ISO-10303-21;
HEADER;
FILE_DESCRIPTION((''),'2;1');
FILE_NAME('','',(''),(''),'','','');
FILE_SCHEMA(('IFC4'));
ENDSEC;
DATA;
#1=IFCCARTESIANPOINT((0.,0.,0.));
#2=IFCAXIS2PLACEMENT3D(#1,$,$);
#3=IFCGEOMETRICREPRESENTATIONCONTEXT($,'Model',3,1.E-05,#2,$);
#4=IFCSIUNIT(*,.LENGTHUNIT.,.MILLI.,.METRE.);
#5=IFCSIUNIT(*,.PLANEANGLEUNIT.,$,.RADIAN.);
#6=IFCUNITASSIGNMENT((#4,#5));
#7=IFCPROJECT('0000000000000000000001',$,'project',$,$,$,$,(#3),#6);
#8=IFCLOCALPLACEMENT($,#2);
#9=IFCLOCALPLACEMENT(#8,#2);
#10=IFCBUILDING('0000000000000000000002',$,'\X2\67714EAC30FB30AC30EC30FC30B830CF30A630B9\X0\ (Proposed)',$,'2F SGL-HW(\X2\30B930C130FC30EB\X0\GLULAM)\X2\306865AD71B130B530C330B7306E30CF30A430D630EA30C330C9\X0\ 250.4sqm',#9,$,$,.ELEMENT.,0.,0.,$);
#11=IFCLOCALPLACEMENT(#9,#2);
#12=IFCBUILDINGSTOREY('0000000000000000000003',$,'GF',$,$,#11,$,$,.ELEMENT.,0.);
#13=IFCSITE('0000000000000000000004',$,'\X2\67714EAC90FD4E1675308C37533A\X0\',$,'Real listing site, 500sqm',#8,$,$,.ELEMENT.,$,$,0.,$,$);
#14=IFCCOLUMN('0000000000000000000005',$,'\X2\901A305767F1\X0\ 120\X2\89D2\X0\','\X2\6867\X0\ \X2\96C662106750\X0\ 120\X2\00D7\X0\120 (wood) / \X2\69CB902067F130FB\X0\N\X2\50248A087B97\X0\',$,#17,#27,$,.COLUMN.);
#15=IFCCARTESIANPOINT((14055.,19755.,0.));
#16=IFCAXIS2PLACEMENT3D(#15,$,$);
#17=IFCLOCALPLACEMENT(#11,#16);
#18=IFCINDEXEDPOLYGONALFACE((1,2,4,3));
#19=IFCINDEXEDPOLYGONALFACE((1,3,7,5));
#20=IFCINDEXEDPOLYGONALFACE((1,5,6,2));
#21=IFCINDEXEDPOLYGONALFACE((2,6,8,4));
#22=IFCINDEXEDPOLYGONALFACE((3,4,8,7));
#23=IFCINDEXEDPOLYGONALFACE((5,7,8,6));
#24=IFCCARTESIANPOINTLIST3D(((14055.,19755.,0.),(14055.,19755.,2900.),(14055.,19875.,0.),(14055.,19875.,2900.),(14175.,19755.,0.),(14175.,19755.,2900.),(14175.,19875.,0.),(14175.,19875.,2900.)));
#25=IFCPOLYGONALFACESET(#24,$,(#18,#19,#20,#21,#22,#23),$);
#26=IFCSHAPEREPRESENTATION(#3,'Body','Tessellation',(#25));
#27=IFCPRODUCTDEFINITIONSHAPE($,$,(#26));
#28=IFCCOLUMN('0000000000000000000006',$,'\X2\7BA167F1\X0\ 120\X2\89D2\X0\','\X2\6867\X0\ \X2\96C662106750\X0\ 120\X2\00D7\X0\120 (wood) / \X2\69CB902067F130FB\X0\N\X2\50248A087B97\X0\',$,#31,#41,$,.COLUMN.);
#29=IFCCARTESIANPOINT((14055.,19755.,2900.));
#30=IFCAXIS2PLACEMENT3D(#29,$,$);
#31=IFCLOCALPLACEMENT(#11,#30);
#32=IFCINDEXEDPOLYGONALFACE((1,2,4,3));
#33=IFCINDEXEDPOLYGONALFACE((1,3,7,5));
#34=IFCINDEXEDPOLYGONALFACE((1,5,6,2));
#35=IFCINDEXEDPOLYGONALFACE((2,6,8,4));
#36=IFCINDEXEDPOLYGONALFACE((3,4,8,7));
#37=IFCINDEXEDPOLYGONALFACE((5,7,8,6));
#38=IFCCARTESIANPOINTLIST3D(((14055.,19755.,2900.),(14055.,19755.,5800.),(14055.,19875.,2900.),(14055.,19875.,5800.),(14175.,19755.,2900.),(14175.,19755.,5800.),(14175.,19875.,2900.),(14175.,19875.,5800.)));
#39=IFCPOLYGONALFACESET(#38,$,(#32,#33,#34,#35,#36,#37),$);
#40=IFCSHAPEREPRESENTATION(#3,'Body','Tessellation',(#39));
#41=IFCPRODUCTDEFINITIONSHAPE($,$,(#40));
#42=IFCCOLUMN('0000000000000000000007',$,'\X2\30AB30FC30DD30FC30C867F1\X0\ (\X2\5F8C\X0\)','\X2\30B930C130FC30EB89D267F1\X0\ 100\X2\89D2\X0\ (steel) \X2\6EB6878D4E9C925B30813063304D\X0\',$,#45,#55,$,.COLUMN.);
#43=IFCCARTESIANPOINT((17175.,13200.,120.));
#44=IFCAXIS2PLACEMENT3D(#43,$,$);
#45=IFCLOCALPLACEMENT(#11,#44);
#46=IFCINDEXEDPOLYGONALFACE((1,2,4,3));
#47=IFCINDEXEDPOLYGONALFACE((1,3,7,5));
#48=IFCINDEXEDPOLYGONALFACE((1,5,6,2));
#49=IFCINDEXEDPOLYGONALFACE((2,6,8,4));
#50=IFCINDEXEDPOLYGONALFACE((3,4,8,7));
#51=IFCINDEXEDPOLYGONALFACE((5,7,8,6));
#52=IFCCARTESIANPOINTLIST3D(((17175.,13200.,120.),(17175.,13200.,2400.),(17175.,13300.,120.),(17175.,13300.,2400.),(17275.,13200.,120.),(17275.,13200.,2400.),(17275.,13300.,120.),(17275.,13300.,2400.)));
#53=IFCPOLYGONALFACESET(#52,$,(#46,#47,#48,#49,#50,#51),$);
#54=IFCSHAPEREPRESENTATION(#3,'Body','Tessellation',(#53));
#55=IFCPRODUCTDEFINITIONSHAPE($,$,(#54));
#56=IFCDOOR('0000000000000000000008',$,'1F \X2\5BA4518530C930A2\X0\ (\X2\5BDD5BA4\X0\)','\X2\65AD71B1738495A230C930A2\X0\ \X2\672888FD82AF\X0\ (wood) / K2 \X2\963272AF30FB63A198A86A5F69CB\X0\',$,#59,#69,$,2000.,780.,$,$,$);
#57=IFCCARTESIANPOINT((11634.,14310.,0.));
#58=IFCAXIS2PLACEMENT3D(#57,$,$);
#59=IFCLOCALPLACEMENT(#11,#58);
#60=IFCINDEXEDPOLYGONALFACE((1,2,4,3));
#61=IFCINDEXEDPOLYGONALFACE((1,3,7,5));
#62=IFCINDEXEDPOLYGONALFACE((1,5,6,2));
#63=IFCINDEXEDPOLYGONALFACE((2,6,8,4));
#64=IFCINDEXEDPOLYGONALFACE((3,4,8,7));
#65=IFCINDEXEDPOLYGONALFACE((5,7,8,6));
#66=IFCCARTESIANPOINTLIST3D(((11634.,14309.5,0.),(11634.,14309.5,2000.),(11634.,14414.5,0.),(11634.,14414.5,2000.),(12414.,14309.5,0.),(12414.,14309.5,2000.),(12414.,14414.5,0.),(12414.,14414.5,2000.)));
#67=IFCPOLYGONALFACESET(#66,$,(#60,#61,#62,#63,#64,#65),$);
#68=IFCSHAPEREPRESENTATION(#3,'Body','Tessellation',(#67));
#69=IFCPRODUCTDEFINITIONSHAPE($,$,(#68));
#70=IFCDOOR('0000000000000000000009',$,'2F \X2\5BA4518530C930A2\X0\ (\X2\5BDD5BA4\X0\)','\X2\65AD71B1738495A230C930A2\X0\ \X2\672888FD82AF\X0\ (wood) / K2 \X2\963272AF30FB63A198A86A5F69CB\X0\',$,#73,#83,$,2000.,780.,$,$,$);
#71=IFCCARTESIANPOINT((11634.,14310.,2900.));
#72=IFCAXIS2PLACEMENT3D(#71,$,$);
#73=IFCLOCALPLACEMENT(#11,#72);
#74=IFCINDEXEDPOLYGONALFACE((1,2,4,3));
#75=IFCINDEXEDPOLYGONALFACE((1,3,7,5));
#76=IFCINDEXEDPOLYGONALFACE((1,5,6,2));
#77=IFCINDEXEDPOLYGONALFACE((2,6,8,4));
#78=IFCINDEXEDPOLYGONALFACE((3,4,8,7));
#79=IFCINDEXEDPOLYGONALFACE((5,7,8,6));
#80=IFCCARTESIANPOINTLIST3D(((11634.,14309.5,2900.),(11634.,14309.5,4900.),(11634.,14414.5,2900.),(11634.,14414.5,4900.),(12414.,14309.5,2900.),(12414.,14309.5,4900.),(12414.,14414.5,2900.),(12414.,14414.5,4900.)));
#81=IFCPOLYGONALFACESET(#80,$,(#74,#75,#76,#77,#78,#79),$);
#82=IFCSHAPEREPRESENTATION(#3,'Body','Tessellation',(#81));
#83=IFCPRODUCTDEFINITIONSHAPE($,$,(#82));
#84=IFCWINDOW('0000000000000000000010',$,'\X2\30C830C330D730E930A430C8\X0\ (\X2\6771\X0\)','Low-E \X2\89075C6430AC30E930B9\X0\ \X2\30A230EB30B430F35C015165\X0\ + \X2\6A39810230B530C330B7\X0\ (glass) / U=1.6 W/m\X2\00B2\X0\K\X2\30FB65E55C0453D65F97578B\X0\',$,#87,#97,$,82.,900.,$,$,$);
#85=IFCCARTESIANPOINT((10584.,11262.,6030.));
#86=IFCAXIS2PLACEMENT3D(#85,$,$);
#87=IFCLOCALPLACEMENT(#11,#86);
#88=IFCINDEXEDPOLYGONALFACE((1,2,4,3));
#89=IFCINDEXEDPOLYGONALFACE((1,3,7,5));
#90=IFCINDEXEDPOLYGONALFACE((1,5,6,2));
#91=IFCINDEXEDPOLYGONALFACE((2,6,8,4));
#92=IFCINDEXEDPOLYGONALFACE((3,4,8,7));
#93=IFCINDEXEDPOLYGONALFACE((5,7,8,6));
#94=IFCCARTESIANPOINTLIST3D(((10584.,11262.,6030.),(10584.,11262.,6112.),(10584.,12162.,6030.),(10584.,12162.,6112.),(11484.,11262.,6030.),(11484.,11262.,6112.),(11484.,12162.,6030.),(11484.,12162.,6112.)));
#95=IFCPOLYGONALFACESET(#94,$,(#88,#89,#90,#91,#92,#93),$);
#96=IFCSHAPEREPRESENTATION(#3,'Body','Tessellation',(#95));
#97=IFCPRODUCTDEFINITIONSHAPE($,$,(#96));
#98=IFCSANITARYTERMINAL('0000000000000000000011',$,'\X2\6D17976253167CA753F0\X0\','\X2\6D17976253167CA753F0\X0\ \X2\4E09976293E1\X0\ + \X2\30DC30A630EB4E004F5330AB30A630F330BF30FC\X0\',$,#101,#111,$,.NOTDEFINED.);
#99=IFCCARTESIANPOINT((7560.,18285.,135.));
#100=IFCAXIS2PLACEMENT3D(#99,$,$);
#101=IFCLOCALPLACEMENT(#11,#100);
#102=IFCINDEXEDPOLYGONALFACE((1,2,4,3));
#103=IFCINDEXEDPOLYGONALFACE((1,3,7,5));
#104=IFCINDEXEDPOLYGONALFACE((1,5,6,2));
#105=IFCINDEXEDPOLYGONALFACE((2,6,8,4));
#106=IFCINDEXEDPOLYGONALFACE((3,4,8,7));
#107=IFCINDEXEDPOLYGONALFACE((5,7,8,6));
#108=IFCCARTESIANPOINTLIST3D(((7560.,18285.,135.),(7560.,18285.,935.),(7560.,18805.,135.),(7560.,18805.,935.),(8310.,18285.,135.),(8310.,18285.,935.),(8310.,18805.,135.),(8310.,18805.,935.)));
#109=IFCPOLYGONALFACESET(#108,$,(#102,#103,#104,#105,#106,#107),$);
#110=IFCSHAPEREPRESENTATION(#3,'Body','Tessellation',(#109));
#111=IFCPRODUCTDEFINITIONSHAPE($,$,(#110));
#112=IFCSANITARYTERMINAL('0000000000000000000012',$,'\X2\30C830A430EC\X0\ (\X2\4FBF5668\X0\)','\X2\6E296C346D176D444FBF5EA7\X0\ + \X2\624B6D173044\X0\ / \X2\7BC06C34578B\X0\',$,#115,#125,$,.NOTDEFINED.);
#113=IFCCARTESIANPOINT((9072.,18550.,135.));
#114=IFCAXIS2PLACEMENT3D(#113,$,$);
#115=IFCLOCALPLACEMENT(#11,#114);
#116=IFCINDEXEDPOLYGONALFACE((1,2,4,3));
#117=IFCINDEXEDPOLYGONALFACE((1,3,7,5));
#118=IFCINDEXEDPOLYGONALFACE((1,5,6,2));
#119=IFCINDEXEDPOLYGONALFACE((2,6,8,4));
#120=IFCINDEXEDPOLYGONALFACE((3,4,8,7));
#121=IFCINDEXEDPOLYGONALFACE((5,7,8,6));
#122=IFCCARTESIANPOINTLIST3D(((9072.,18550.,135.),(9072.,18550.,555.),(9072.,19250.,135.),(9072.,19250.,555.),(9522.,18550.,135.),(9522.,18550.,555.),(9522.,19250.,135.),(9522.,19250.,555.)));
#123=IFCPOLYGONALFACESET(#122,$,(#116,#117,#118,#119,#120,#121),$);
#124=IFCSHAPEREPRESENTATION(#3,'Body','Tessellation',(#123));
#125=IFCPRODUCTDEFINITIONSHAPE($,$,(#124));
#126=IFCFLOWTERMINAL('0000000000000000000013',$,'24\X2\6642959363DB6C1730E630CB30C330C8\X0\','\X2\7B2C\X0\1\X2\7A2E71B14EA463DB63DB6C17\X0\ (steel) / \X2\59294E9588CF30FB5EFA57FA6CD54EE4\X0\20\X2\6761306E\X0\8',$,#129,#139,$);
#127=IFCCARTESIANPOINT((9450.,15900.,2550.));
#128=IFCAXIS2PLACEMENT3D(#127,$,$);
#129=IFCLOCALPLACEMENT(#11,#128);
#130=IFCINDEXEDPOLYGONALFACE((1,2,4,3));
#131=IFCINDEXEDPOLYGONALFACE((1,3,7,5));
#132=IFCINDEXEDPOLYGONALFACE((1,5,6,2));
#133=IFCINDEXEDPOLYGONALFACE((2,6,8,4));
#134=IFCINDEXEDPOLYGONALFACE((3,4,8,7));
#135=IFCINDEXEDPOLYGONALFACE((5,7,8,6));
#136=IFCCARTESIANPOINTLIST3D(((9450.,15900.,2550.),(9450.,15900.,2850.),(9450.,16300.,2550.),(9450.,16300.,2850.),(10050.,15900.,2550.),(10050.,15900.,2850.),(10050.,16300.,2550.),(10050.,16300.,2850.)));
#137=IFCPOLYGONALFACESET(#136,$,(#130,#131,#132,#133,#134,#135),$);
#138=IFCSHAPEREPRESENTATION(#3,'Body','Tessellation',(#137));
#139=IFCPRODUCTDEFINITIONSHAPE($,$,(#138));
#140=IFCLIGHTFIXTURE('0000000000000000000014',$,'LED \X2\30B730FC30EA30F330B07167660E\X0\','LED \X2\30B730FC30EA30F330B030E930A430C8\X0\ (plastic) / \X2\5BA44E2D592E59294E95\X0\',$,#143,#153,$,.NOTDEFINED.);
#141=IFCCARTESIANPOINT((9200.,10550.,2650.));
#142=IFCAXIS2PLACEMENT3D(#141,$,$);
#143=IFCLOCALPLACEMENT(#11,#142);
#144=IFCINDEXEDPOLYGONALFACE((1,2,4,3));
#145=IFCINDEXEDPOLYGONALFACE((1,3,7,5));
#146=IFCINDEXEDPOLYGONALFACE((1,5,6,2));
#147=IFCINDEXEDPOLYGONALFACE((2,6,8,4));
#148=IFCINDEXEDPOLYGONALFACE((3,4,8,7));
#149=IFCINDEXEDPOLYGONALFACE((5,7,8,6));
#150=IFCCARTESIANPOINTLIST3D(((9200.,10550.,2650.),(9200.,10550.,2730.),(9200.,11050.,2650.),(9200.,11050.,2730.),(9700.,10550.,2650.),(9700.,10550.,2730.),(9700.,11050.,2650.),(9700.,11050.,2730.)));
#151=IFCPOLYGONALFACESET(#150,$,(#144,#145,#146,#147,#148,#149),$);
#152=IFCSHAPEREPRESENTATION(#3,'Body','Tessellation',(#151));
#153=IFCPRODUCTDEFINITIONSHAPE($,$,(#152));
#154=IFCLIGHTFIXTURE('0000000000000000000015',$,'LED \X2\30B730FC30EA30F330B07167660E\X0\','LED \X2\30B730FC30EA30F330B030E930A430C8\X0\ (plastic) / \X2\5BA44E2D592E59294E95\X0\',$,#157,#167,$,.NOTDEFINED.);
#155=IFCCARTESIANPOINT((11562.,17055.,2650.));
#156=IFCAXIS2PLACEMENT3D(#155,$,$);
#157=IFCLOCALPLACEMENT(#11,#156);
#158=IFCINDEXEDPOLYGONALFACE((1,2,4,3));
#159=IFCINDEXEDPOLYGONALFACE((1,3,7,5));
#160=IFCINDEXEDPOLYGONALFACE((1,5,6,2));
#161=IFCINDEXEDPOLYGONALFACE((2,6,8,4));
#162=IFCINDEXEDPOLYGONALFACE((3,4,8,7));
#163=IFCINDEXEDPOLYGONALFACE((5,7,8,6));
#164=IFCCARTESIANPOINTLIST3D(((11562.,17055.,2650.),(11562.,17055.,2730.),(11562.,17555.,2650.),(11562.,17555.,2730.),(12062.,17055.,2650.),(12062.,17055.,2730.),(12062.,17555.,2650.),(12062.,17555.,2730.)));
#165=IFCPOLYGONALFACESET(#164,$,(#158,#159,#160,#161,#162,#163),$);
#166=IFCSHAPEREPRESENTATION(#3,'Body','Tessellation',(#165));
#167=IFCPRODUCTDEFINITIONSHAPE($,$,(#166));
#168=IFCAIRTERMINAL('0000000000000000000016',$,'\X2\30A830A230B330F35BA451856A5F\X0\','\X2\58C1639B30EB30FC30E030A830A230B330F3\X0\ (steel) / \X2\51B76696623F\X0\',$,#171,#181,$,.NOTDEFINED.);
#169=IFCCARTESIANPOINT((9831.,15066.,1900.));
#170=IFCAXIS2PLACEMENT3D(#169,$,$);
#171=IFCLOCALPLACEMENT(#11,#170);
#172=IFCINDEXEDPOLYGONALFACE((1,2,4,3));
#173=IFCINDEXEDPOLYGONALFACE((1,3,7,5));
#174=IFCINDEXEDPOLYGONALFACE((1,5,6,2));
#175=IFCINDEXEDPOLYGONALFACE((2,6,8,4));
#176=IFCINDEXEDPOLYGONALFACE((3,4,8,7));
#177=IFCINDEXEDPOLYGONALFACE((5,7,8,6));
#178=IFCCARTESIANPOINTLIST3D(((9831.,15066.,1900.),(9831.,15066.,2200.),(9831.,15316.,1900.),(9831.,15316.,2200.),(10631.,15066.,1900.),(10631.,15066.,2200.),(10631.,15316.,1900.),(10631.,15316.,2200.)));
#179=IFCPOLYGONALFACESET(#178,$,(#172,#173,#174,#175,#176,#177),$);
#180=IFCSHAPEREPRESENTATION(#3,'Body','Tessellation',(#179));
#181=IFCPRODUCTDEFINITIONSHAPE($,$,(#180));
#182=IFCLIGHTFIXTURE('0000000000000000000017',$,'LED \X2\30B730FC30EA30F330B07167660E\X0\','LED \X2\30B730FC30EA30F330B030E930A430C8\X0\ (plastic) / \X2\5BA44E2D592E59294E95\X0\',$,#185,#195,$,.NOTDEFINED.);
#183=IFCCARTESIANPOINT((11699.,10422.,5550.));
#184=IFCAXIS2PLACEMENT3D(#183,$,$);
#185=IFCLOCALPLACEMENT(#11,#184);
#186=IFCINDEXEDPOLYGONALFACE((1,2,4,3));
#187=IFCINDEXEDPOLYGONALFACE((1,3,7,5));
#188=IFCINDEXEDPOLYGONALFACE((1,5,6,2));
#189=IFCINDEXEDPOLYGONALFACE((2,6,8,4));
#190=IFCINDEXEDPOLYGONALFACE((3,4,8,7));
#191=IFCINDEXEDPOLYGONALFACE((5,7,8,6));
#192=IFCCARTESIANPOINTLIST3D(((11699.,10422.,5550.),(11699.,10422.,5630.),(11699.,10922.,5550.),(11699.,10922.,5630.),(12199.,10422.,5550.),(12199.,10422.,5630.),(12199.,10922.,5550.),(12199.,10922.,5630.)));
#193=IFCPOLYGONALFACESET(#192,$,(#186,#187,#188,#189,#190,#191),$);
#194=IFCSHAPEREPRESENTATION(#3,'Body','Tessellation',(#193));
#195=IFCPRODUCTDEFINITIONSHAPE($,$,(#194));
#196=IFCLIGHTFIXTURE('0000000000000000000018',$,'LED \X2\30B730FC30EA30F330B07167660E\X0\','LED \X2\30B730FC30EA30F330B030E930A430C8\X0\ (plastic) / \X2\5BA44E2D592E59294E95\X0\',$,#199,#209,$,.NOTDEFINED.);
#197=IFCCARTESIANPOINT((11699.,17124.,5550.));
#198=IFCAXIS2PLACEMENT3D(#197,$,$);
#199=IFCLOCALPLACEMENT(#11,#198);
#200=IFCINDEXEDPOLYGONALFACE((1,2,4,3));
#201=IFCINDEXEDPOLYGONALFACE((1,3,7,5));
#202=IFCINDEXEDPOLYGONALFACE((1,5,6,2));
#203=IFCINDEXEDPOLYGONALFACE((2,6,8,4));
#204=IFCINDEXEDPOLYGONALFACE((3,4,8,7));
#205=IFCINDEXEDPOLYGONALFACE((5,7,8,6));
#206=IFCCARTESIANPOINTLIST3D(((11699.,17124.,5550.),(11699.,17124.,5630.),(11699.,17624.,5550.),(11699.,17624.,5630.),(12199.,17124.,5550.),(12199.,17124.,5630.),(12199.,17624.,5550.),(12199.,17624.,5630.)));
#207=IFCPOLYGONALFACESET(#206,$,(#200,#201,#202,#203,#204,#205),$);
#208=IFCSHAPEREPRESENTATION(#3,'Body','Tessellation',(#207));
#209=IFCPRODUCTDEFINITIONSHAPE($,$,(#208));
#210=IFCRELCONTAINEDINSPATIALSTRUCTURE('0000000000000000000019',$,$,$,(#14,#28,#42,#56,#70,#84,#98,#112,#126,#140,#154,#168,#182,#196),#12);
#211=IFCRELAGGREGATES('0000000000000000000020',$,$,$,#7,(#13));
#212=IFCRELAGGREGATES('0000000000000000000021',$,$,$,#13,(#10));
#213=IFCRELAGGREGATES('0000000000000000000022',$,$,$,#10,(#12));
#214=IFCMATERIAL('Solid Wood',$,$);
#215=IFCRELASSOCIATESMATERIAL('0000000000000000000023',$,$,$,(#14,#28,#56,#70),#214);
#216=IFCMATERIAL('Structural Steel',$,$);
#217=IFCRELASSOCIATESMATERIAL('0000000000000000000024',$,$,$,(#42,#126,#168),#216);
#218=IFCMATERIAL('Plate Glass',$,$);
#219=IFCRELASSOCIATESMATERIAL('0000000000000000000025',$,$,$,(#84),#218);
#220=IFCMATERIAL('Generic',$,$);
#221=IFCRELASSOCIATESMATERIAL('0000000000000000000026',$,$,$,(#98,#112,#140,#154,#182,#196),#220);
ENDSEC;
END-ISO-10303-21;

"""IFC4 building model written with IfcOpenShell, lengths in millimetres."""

from ifc_helpers import new_model, si_unit, frame, frame_2d, origin, place, context, project, spatial, rectangle, extrude, material, element, save


model = new_model("IFC4")

# Units and contexts
model_context = context("Model", 3, precision=1e-05, world=origin())
ifc_project = project(units=[si_unit("LENGTHUNIT", "METRE", prefix="MILLI"), si_unit("PLANEANGLEUNIT", "RADIAN")], contexts=[model_context])

# Site, building, storey
site_placement = place(None, origin())
site = spatial("IfcSite", under=ifc_project, at=site_placement, Name="東京都世田谷区", ObjectType="Real listing site, 500sqm", CompositionType="ELEMENT", RefElevation=0.0)
building_placement = place(site_placement, origin())
building = spatial("IfcBuilding", under=site, at=building_placement, Name="東京・ガレージハウス (Proposed)", ObjectType="2F SGL-HW(スチールGLULAM)と断熱サッシのハイブリッド 250.4sqm", CompositionType="ELEMENT", ElevationOfRefHeight=0.0, ElevationOfTerrain=0.0)
storey_placement = place(building_placement, origin())
storey = spatial("IfcBuildingStorey", under=building, at=storey_placement, Name="GF", CompositionType="ELEMENT", Elevation=0.0)

# Columns
ifc_material_1 = material(Name="Solid Wood")
column_1_placement = place(storey_placement, frame((14055.0, 19755.0, 0.0)))
element("IfcColumn", 1, at=column_1_placement, inside=storey, material=ifc_material_1, Name="通し柱 120角", Description="桧 集成材 120×120 (wood) / 構造柱・N値計算", PredefinedType="COLUMN", context=model_context, shape_type="SweptSolid", body=[
    extrude(rectangle(XDim=120.0, YDim=120.0, at=frame_2d((60.0, 60.0))), frame((14055.0, 19755.0, 0.0)), (0.0, 0.0, 1.0), 2900.0),
])
column_2_placement = place(storey_placement, frame((14055.0, 19755.0, 2900.0)))
element("IfcColumn", 2, at=column_2_placement, inside=storey, material=ifc_material_1, Name="管柱 120角", Description="桧 集成材 120×120 (wood) / 構造柱・N値計算", PredefinedType="COLUMN", context=model_context, shape_type="SweptSolid", body=[
    extrude(rectangle(XDim=120.0, YDim=120.0, at=frame_2d((60.0, 60.0))), frame((14055.0, 19755.0, 2900.0)), (0.0, 0.0, 1.0), 2900.0),
])
ifc_material_2 = material(Name="Structural Steel")
column_3_placement = place(storey_placement, frame((17175.0, 13200.0, 120.0)))
element("IfcColumn", 3, at=column_3_placement, inside=storey, material=ifc_material_2, Name="カーポート柱 (後)", Description="スチール角柱 100角 (steel) 溶融亜鉛めっき", PredefinedType="COLUMN", context=model_context, shape_type="SweptSolid", body=[
    extrude(rectangle(XDim=100.0, YDim=100.0, at=frame_2d((50.0, 50.0))), frame((17175.0, 13200.0, 120.0)), (0.0, 0.0, 1.0), 2280.0),
])

# Door
door_1_placement = place(storey_placement, frame((11634.0, 14310.0, 0.0)))
element("IfcDoor", 4, at=door_1_placement, inside=storey, material=ifc_material_1, Name="1F 室内ドア (寝室)", Description="断熱玄関ドア 木製芯 (wood) / K2 防犯・採風機構", OverallHeight=2000.0, OverallWidth=780.0, context=model_context, shape_type="SweptSolid", body=[
    extrude(rectangle(XDim=780.0, YDim=105.0, at=frame_2d((390.0, 52.0))), frame((11634.0, 14310.0, 0.0)), (0.0, 0.0, 1.0), 2000.0),
])

# Door
door_2_placement = place(storey_placement, frame((11634.0, 14310.0, 2900.0)))
element("IfcDoor", 5, at=door_2_placement, inside=storey, material=ifc_material_1, Name="2F 室内ドア (寝室)", Description="断熱玄関ドア 木製芯 (wood) / K2 防犯・採風機構", OverallHeight=2000.0, OverallWidth=780.0, context=model_context, shape_type="SweptSolid", body=[
    extrude(rectangle(XDim=780.0, YDim=105.0, at=frame_2d((390.0, 52.0))), frame((11634.0, 14310.0, 2900.0)), (0.0, 0.0, 1.0), 2000.0),
])

# Window
ifc_material_3 = material(Name="Plate Glass")
window_placement = place(storey_placement, frame((10584.0, 11262.0, 6030.0)))
element("IfcWindow", 6, at=window_placement, inside=storey, material=ifc_material_3, Name="トップライト (東)", Description="Low-E 複層ガラス アルゴン封入 + 樹脂サッシ (glass) / U=1.6 W/m²K・日射取得型", OverallHeight=82.0, OverallWidth=900.0, context=model_context, shape_type="SweptSolid", body=[
    extrude(rectangle(XDim=900.0, YDim=900.0, at=frame_2d((450.0, 450.0))), frame((10584.0, 11262.0, 6030.0)), (0.0, 0.0, 1.0), 82.0),
])

# Sanitary terminals
ifc_material_4 = material(Name="Generic")
sanitary_terminal_1_placement = place(storey_placement, frame((7560.0, 18285.0, 135.0)))
element("IfcSanitaryTerminal", 7, at=sanitary_terminal_1_placement, inside=storey, material=ifc_material_4, Name="洗面化粧台", Description="洗面化粧台 三面鏡 + ボウル一体カウンター", PredefinedType="NOTDEFINED", context=model_context, shape_type="SweptSolid", body=[
    extrude(rectangle(XDim=750.0, YDim=520.0, at=frame_2d((375.0, 260.0))), frame((7560.0, 18285.0, 135.0)), (0.0, 0.0, 1.0), 800.0),
])
sanitary_terminal_2_placement = place(storey_placement, frame((9072.0, 18550.0, 135.0)))
element("IfcSanitaryTerminal", 8, at=sanitary_terminal_2_placement, inside=storey, material=ifc_material_4, Name="トイレ (便器)", Description="温水洗浄便座 + 手洗い / 節水型", PredefinedType="NOTDEFINED", context=model_context, shape_type="SweptSolid", body=[
    extrude(rectangle(XDim=450.0, YDim=700.0, at=frame_2d((225.0, 350.0))), frame((9072.0, 18550.0, 135.0)), (0.0, 0.0, 1.0), 420.0),
])

# Flow terminal
flow_terminal_placement = place(storey_placement, frame((9450.0, 15900.0, 2550.0)))
element("IfcFlowTerminal", 9, at=flow_terminal_placement, inside=storey, material=ifc_material_2, Name="24時間換気ユニット", Description="第1種熱交換換気 (steel) / 天井裏・建基法令20条の8", context=model_context, shape_type="SweptSolid", body=[
    extrude(rectangle(XDim=600.0, YDim=400.0, at=frame_2d((300.0, 200.0))), frame((9450.0, 15900.0, 2550.0)), (0.0, 0.0, 1.0), 300.0),
])

# Light fixtures
light_fixture_1_placement = place(storey_placement, frame((9200.0, 10550.0, 2650.0)))
element("IfcLightFixture", 10, at=light_fixture_1_placement, inside=storey, material=ifc_material_4, Name="LED シーリング照明", Description="LED シーリングライト (plastic) / 室中央天井", PredefinedType="NOTDEFINED", context=model_context, shape_type="SweptSolid", body=[
    extrude(rectangle(XDim=500.0, YDim=500.0, at=frame_2d((250.0, 250.0))), frame((9200.0, 10550.0, 2650.0)), (0.0, 0.0, 1.0), 80.0),
])
light_fixture_2_placement = place(storey_placement, frame((11562.0, 17055.0, 2650.0)))
element("IfcLightFixture", 11, at=light_fixture_2_placement, inside=storey, material=ifc_material_4, Name="LED シーリング照明", Description="LED シーリングライト (plastic) / 室中央天井", PredefinedType="NOTDEFINED", context=model_context, shape_type="SweptSolid", body=[
    extrude(rectangle(XDim=500.0, YDim=500.0, at=frame_2d((250.0, 250.0))), frame((11562.0, 17055.0, 2650.0)), (0.0, 0.0, 1.0), 80.0),
])

# Air terminal
air_terminal_placement = place(storey_placement, frame((9831.0, 15066.0, 1900.0)))
element("IfcAirTerminal", 12, at=air_terminal_placement, inside=storey, material=ifc_material_2, Name="エアコン室内機", Description="壁掛ルームエアコン (steel) / 冷暖房", PredefinedType="NOTDEFINED", context=model_context, shape_type="SweptSolid", body=[
    extrude(rectangle(XDim=800.0, YDim=250.0, at=frame_2d((400.0, 125.0))), frame((9831.0, 15066.0, 1900.0)), (0.0, 0.0, 1.0), 300.0),
])

# Light fixtures
light_fixture_3_placement = place(storey_placement, frame((11699.0, 10422.0, 5550.0)))
element("IfcLightFixture", 13, at=light_fixture_3_placement, inside=storey, material=ifc_material_4, Name="LED シーリング照明", Description="LED シーリングライト (plastic) / 室中央天井", PredefinedType="NOTDEFINED", context=model_context, shape_type="SweptSolid", body=[
    extrude(rectangle(XDim=500.0, YDim=500.0, at=frame_2d((250.0, 250.0))), frame((11699.0, 10422.0, 5550.0)), (0.0, 0.0, 1.0), 80.0),
])
light_fixture_4_placement = place(storey_placement, frame((11699.0, 17124.0, 5550.0)))
element("IfcLightFixture", 14, at=light_fixture_4_placement, inside=storey, material=ifc_material_4, Name="LED シーリング照明", Description="LED シーリングライト (plastic) / 室中央天井", PredefinedType="NOTDEFINED", context=model_context, shape_type="SweptSolid", body=[
    extrude(rectangle(XDim=500.0, YDim=500.0, at=frame_2d((250.0, 250.0))), frame((11699.0, 17124.0, 5550.0)), (0.0, 0.0, 1.0), 80.0),
])

save(model, "model.ifc")
